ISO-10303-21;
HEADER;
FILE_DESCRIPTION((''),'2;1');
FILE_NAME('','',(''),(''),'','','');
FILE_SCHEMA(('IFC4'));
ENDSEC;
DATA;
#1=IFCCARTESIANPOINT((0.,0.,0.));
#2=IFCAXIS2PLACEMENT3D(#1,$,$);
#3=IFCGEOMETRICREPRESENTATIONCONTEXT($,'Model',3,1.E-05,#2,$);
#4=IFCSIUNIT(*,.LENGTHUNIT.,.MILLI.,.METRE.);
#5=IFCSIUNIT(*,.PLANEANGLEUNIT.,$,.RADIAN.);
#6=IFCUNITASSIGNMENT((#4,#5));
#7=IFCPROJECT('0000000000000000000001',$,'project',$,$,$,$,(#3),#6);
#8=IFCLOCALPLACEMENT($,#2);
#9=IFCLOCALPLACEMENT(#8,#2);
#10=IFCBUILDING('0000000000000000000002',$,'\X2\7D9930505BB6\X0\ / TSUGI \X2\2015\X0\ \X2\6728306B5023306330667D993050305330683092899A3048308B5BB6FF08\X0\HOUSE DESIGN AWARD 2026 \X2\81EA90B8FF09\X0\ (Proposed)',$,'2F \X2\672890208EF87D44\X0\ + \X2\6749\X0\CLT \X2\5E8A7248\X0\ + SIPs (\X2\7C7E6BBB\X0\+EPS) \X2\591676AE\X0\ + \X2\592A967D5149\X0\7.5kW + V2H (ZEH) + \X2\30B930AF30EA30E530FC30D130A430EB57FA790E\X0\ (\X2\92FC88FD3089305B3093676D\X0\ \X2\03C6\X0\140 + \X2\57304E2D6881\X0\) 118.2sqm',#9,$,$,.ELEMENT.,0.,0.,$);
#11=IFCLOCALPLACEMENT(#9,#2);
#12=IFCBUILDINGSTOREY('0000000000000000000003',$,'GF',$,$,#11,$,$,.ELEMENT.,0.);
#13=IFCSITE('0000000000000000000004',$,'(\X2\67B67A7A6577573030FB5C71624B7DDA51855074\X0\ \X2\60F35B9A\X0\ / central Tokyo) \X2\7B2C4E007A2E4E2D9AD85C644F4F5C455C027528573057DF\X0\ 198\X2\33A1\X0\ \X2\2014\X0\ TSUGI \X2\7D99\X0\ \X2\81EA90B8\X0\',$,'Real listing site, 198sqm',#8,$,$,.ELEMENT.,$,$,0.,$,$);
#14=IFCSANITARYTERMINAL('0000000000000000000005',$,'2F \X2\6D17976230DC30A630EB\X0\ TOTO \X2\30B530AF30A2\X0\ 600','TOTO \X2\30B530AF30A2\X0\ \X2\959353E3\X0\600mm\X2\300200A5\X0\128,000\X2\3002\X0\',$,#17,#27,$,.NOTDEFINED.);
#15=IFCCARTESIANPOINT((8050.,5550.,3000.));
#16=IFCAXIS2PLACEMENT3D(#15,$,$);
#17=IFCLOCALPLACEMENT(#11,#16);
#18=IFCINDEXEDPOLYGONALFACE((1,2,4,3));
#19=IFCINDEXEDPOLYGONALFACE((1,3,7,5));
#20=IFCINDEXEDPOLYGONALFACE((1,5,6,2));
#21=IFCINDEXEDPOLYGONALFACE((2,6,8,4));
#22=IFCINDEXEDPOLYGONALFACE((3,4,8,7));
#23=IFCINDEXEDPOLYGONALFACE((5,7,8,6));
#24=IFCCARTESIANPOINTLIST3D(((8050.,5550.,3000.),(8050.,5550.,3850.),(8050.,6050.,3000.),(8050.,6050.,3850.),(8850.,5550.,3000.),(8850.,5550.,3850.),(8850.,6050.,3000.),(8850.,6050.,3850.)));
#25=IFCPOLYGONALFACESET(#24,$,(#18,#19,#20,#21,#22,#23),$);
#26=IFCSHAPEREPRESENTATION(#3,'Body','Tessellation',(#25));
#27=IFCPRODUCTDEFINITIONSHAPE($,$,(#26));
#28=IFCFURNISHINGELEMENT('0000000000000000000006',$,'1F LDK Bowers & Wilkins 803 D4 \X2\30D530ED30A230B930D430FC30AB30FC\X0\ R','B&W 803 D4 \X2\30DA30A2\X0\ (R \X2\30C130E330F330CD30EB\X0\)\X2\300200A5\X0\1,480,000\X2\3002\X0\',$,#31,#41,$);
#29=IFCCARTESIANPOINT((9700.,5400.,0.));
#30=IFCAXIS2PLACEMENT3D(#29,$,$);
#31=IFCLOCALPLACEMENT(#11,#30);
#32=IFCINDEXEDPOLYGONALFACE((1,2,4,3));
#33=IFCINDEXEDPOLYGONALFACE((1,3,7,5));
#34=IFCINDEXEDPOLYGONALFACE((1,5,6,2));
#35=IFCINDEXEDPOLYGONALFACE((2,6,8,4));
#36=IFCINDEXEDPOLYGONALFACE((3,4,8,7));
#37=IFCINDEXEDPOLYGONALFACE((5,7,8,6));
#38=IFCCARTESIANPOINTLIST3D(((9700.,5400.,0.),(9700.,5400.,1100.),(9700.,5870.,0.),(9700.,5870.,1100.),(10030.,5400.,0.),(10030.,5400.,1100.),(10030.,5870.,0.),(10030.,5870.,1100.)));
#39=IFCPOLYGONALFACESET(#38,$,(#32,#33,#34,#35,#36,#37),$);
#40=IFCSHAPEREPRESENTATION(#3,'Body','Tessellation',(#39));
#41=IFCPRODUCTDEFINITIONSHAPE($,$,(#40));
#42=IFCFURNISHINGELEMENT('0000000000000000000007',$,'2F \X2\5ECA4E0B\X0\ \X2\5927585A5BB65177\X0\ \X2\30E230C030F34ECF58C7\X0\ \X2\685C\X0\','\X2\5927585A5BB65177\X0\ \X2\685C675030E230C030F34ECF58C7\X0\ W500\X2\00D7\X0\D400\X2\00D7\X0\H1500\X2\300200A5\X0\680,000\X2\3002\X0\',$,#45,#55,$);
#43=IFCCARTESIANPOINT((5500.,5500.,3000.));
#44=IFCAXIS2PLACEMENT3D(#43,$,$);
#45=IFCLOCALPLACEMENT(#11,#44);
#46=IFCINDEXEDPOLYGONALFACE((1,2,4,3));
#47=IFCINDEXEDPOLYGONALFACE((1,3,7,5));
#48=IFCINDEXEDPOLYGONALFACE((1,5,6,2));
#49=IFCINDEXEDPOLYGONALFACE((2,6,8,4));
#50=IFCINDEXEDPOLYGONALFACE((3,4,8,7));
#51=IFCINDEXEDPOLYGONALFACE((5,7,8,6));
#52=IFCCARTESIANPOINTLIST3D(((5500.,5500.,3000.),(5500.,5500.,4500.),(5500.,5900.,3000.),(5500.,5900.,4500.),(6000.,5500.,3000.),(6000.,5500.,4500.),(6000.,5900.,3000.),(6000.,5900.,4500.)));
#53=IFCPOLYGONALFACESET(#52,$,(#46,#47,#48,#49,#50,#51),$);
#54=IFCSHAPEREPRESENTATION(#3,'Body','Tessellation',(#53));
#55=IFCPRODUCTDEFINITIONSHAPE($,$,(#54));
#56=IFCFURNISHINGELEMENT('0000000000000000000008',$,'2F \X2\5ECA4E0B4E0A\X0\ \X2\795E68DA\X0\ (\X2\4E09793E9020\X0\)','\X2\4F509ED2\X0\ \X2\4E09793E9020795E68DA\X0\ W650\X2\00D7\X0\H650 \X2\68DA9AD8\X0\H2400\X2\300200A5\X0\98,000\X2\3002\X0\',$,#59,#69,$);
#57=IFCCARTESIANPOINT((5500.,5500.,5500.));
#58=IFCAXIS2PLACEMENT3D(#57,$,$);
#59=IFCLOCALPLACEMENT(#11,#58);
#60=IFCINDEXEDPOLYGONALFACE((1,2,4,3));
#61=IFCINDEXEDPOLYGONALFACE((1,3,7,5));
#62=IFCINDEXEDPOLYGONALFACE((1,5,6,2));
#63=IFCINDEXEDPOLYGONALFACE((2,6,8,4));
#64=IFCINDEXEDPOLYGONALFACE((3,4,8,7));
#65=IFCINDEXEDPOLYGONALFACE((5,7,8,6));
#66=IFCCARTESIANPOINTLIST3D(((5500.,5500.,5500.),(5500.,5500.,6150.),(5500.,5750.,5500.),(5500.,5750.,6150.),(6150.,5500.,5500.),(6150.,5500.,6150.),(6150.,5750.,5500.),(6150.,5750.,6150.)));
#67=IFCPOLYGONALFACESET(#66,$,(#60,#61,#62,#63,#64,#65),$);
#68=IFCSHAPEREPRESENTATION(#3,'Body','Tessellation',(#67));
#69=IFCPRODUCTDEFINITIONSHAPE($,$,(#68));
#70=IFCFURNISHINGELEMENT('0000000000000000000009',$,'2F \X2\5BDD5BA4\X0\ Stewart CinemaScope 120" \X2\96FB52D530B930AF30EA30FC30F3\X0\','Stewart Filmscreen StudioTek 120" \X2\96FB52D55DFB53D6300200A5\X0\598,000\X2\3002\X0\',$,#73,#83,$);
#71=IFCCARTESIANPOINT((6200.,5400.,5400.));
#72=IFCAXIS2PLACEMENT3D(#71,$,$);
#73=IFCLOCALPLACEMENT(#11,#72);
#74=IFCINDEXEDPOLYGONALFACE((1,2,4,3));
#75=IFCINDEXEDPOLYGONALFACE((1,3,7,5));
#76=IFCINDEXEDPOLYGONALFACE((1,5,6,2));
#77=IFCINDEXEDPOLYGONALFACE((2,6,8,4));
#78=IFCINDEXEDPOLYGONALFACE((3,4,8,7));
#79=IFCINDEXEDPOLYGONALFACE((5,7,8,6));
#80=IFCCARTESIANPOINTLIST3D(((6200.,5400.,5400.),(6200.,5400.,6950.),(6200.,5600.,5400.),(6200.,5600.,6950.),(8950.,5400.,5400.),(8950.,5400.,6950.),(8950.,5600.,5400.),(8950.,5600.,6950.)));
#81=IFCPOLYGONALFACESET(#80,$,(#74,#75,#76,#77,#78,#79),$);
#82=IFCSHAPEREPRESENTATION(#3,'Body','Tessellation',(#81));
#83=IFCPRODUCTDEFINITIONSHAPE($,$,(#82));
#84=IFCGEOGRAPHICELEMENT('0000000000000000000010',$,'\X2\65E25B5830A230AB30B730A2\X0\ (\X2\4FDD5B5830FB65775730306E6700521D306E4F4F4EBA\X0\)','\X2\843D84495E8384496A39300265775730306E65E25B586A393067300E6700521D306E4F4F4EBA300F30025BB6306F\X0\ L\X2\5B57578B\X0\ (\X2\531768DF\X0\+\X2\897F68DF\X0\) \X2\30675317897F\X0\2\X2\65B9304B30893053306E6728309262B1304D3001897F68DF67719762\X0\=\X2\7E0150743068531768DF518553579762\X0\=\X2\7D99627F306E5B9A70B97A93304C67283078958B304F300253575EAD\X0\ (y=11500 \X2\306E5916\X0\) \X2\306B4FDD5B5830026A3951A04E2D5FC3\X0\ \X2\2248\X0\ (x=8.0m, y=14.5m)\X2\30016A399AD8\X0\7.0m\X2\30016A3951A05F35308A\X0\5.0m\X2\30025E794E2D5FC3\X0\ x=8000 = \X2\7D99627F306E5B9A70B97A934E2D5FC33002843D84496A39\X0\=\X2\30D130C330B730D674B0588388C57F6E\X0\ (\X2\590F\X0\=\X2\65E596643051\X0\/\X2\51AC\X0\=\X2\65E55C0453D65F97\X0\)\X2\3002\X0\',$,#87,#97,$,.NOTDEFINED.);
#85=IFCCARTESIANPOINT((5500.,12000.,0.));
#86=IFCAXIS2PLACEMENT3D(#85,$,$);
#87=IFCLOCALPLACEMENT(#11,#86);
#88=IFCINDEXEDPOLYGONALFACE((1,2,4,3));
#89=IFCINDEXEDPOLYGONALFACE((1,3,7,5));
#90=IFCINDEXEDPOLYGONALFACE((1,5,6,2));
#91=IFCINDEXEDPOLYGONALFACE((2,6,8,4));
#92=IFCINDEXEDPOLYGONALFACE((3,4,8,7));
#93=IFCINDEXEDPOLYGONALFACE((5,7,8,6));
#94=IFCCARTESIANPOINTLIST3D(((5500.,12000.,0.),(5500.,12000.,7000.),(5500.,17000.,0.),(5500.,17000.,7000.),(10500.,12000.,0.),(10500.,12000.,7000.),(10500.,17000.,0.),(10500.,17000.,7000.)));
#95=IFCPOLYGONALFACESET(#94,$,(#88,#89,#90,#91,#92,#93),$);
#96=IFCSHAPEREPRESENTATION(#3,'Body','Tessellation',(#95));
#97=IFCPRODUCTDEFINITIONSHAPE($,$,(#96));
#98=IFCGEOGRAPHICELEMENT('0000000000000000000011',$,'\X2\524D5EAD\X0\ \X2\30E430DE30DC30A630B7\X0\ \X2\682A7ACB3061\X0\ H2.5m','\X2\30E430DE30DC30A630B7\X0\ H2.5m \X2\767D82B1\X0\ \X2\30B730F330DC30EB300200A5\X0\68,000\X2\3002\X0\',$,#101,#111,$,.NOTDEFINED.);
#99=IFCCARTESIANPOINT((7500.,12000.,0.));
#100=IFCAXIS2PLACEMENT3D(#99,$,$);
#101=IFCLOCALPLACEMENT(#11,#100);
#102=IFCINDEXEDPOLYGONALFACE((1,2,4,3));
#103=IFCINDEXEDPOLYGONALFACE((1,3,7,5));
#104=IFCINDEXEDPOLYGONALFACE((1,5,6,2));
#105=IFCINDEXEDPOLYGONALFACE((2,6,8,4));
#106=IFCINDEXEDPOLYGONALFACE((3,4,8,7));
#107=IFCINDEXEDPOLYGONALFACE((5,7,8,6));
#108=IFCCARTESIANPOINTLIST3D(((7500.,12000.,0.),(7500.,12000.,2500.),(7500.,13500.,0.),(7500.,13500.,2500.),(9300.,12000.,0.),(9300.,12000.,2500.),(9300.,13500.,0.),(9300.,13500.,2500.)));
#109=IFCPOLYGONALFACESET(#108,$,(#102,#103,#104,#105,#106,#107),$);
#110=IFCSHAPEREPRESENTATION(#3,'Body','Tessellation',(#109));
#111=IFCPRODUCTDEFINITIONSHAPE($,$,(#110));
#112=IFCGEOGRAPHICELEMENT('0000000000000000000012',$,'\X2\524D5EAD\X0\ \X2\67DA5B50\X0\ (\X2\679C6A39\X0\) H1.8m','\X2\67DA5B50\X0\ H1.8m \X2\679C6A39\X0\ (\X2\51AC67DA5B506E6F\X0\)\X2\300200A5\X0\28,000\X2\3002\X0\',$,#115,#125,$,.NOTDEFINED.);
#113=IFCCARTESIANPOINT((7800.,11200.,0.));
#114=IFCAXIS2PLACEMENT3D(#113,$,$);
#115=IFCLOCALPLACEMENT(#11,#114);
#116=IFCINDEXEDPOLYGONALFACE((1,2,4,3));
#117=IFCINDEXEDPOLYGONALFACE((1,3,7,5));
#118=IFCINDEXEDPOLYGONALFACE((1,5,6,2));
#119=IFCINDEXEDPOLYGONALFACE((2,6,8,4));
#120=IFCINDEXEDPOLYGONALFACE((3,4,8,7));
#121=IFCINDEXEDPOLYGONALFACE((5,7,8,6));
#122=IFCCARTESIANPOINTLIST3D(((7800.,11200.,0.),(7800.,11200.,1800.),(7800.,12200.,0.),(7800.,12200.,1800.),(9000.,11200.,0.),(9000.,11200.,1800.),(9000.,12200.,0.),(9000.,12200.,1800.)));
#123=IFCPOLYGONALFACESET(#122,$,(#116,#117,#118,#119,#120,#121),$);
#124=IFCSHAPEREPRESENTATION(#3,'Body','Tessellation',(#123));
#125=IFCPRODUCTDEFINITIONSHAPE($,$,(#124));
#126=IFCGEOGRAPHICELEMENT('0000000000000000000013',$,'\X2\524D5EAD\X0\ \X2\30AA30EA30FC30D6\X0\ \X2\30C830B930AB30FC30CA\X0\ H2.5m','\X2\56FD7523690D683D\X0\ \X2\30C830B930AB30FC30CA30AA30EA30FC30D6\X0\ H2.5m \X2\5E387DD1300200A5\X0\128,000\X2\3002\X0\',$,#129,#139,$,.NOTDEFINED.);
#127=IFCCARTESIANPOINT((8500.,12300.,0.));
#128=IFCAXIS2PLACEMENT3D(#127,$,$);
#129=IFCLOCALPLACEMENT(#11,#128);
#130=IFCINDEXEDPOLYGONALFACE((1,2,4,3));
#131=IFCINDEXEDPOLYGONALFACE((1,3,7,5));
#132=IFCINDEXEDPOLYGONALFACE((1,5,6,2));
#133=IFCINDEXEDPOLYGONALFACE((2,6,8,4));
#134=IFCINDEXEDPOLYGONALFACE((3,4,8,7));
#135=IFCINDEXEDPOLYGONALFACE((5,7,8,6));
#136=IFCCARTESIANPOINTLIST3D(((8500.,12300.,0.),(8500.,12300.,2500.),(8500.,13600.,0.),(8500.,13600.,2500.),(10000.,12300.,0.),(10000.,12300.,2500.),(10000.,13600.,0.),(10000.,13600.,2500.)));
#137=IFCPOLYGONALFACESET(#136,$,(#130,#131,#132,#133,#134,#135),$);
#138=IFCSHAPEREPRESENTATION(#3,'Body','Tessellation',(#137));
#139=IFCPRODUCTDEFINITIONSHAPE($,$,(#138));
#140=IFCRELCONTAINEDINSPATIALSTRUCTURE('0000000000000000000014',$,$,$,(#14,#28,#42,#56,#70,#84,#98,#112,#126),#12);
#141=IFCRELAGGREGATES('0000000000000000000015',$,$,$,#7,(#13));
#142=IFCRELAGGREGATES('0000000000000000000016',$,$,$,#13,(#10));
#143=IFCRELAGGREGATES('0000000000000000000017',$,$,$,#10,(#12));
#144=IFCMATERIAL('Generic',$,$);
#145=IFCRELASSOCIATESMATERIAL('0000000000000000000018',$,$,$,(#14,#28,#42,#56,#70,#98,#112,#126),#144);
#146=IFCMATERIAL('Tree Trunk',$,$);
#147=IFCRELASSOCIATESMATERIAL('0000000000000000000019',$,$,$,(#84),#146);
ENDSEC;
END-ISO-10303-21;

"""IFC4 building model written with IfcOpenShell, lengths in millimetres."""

from ifc_helpers import new_model, si_unit, frame, frame_2d, origin, place, context, project, spatial, rectangle, extrude, material, element, save


model = new_model("IFC4")

# Units and contexts
model_context = context("Model", 3, precision=1e-05, world=origin())
ifc_project = project(units=[si_unit("LENGTHUNIT", "METRE", prefix="MILLI"), si_unit("PLANEANGLEUNIT", "RADIAN")], contexts=[model_context])

# Site, building, storey
site_placement = place(None, origin())
site = spatial("IfcSite", under=ifc_project, at=site_placement, Name="(架空敷地・山手線内側 想定 / central Tokyo) 第一種中高層住居専用地域 198㎡ — TSUGI 継 自邸", ObjectType="Real listing site, 198sqm", CompositionType="ELEMENT", RefElevation=0.0)
building_placement = place(site_placement, origin())
building = spatial("IfcBuilding", under=site, at=building_placement, Name="継ぐ家 / TSUGI ― 木に倣って継ぐことを覚える家（HOUSE DESIGN AWARD 2026 自邸） (Proposed)", ObjectType="2F 木造軸組 + 杉CLT 床版 + SIPs (籾殻+EPS) 外皮 + 太陽光7.5kW + V2H (ZEH) + スクリューパイル基礎 (鋼製らせん杭 φ140 + 地中梁) 118.2sqm", CompositionType="ELEMENT", ElevationOfRefHeight=0.0, ElevationOfTerrain=0.0)
storey_placement = place(building_placement, origin())
storey = spatial("IfcBuildingStorey", under=building, at=storey_placement, Name="GF", CompositionType="ELEMENT", Elevation=0.0)

# Shared definitions
ifc_material_1 = material(Name="Tree Trunk")
ifc_material_2 = material(Name="Generic")

# Sanitary terminal
sanitary_terminal_1_placement = place(storey_placement, frame((8050.0, 5550.0, 3000.0)))
element("IfcSanitaryTerminal", 1, at=sanitary_terminal_1_placement, inside=storey, material=ifc_material_2, Name="2F 洗面ボウル TOTO サクア 600", Description="TOTO サクア 間口600mm。¥128,000。", PredefinedType="NOTDEFINED", context=model_context, shape_type="SweptSolid", body=[
    extrude(rectangle(XDim=800.0, YDim=500.0, at=frame_2d((400.0, 250.0))), frame((8050.0, 5550.0, 3000.0)), (0.0, 0.0, 1.0), 850.0),
])

# Furnishing elements
furnishing_1_placement = place(storey_placement, frame((9700.0, 5400.0, 0.0)))
element("IfcFurnishingElement", 2, at=furnishing_1_placement, inside=storey, material=ifc_material_2, Name="1F LDK Bowers & Wilkins 803 D4 フロアスピーカー R", Description="B&W 803 D4 ペア (R チャンネル)。¥1,480,000。", context=model_context, shape_type="SweptSolid", body=[
    extrude(rectangle(XDim=330.0, YDim=470.0, at=frame_2d((165.0, 235.0))), frame((9700.0, 5400.0, 0.0)), (0.0, 0.0, 1.0), 1100.0),
])
furnishing_2_placement = place(storey_placement, frame((5500.0, 5500.0, 3000.0)))
element("IfcFurnishingElement", 3, at=furnishing_2_placement, inside=storey, material=ifc_material_2, Name="2F 廊下 大塚家具 モダン仏壇 桜", Description="大塚家具 桜材モダン仏壇 W500×D400×H1500。¥680,000。", context=model_context, shape_type="SweptSolid", body=[
    extrude(rectangle(XDim=500.0, YDim=400.0, at=frame_2d((250.0, 200.0))), frame((5500.0, 5500.0, 3000.0)), (0.0, 0.0, 1.0), 1500.0),
])
furnishing_3_placement = place(storey_placement, frame((5500.0, 5500.0, 5500.0)))
element("IfcFurnishingElement", 4, at=furnishing_3_placement, inside=storey, material=ifc_material_2, Name="2F 廊下上 神棚 (三社造)", Description="佐黒 三社造神棚 W650×H650 棚高H2400。¥98,000。", context=model_context, shape_type="SweptSolid", body=[
    extrude(rectangle(XDim=650.0, YDim=250.0, at=frame_2d((325.0, 125.0))), frame((5500.0, 5500.0, 5500.0)), (0.0, 0.0, 1.0), 650.0),
])
furnishing_4_placement = place(storey_placement, frame((6200.0, 5400.0, 5400.0)))
element("IfcFurnishingElement", 5, at=furnishing_4_placement, inside=storey, material=ifc_material_2, Name="2F 寝室 Stewart CinemaScope 120\" 電動スクリーン", Description="Stewart Filmscreen StudioTek 120\" 電動巻取。¥598,000。", context=model_context, shape_type="SweptSolid", body=[
    extrude(rectangle(XDim=2750.0, YDim=200.0, at=frame_2d((1375.0, 100.0))), frame((6200.0, 5400.0, 5400.0)), (0.0, 0.0, 1.0), 1550.0),
])

# Geographic elements
geographic_element_1_placement = place(storey_placement, frame((5500.0, 12000.0, 0.0)))
element("IfcGeographicElement", 6, at=geographic_element_1_placement, inside=storey, material=ifc_material_1, Name="既存アカシア (保存・敷地の最初の住人)", Description="落葉広葉樹。敷地の既存樹で『最初の住人』。家は L字型 (北棟+西棟) で北西2方からこの木を抱き、西棟東面=縁側と北棟内南面=継承の定点窓が木へ開く。南庭 (y=11500 の外) に保存。樹冠中心 ≈ (x=8.0m, y=14.5m)、樹高7.0m、樹冠張り5.0m。幹中心 x=8000 = 継承の定点窓中心。落葉樹=パッシブ環境装置 (夏=日除け/冬=日射取得)。", PredefinedType="NOTDEFINED", context=model_context, shape_type="SweptSolid", body=[
    extrude(rectangle(XDim=5000.0, YDim=5000.0, at=frame_2d((2500.0, 2500.0))), frame((5500.0, 12000.0, 0.0)), (0.0, 0.0, 1.0), 7000.0),
])
geographic_element_2_placement = place(storey_placement, frame((7500.0, 12000.0, 0.0)))
element("IfcGeographicElement", 7, at=geographic_element_2_placement, inside=storey, material=ifc_material_2, Name="前庭 ヤマボウシ 株立ち H2.5m", Description="ヤマボウシ H2.5m 白花 シンボル。¥68,000。", PredefinedType="NOTDEFINED", context=model_context, shape_type="SweptSolid", body=[
    extrude(rectangle(XDim=1800.0, YDim=1500.0, at=frame_2d((900.0, 750.0))), frame((7500.0, 12000.0, 0.0)), (0.0, 0.0, 1.0), 2500.0),
])
geographic_element_3_placement = place(storey_placement, frame((7800.0, 11200.0, 0.0)))
element("IfcGeographicElement", 8, at=geographic_element_3_placement, inside=storey, material=ifc_material_2, Name="前庭 柚子 (果樹) H1.8m", Description="柚子 H1.8m 果樹 (冬柚子湯)。¥28,000。", PredefinedType="NOTDEFINED", context=model_context, shape_type="SweptSolid", body=[
    extrude(rectangle(XDim=1200.0, YDim=1000.0, at=frame_2d((600.0, 500.0))), frame((7800.0, 11200.0, 0.0)), (0.0, 0.0, 1.0), 1800.0),
])
geographic_element_4_placement = place(storey_placement, frame((8500.0, 12300.0, 0.0)))
element("IfcGeographicElement", 9, at=geographic_element_4_placement, inside=storey, material=ifc_material_2, Name="前庭 オリーブ トスカーナ H2.5m", Description="国産植栽 トスカーナオリーブ H2.5m 常緑。¥128,000。", PredefinedType="NOTDEFINED", context=model_context, shape_type="SweptSolid", body=[
    extrude(rectangle(XDim=1500.0, YDim=1300.0, at=frame_2d((750.0, 650.0))), frame((8500.0, 12300.0, 0.0)), (0.0, 0.0, 1.0), 2500.0),
])

save(model, "model.ifc")
